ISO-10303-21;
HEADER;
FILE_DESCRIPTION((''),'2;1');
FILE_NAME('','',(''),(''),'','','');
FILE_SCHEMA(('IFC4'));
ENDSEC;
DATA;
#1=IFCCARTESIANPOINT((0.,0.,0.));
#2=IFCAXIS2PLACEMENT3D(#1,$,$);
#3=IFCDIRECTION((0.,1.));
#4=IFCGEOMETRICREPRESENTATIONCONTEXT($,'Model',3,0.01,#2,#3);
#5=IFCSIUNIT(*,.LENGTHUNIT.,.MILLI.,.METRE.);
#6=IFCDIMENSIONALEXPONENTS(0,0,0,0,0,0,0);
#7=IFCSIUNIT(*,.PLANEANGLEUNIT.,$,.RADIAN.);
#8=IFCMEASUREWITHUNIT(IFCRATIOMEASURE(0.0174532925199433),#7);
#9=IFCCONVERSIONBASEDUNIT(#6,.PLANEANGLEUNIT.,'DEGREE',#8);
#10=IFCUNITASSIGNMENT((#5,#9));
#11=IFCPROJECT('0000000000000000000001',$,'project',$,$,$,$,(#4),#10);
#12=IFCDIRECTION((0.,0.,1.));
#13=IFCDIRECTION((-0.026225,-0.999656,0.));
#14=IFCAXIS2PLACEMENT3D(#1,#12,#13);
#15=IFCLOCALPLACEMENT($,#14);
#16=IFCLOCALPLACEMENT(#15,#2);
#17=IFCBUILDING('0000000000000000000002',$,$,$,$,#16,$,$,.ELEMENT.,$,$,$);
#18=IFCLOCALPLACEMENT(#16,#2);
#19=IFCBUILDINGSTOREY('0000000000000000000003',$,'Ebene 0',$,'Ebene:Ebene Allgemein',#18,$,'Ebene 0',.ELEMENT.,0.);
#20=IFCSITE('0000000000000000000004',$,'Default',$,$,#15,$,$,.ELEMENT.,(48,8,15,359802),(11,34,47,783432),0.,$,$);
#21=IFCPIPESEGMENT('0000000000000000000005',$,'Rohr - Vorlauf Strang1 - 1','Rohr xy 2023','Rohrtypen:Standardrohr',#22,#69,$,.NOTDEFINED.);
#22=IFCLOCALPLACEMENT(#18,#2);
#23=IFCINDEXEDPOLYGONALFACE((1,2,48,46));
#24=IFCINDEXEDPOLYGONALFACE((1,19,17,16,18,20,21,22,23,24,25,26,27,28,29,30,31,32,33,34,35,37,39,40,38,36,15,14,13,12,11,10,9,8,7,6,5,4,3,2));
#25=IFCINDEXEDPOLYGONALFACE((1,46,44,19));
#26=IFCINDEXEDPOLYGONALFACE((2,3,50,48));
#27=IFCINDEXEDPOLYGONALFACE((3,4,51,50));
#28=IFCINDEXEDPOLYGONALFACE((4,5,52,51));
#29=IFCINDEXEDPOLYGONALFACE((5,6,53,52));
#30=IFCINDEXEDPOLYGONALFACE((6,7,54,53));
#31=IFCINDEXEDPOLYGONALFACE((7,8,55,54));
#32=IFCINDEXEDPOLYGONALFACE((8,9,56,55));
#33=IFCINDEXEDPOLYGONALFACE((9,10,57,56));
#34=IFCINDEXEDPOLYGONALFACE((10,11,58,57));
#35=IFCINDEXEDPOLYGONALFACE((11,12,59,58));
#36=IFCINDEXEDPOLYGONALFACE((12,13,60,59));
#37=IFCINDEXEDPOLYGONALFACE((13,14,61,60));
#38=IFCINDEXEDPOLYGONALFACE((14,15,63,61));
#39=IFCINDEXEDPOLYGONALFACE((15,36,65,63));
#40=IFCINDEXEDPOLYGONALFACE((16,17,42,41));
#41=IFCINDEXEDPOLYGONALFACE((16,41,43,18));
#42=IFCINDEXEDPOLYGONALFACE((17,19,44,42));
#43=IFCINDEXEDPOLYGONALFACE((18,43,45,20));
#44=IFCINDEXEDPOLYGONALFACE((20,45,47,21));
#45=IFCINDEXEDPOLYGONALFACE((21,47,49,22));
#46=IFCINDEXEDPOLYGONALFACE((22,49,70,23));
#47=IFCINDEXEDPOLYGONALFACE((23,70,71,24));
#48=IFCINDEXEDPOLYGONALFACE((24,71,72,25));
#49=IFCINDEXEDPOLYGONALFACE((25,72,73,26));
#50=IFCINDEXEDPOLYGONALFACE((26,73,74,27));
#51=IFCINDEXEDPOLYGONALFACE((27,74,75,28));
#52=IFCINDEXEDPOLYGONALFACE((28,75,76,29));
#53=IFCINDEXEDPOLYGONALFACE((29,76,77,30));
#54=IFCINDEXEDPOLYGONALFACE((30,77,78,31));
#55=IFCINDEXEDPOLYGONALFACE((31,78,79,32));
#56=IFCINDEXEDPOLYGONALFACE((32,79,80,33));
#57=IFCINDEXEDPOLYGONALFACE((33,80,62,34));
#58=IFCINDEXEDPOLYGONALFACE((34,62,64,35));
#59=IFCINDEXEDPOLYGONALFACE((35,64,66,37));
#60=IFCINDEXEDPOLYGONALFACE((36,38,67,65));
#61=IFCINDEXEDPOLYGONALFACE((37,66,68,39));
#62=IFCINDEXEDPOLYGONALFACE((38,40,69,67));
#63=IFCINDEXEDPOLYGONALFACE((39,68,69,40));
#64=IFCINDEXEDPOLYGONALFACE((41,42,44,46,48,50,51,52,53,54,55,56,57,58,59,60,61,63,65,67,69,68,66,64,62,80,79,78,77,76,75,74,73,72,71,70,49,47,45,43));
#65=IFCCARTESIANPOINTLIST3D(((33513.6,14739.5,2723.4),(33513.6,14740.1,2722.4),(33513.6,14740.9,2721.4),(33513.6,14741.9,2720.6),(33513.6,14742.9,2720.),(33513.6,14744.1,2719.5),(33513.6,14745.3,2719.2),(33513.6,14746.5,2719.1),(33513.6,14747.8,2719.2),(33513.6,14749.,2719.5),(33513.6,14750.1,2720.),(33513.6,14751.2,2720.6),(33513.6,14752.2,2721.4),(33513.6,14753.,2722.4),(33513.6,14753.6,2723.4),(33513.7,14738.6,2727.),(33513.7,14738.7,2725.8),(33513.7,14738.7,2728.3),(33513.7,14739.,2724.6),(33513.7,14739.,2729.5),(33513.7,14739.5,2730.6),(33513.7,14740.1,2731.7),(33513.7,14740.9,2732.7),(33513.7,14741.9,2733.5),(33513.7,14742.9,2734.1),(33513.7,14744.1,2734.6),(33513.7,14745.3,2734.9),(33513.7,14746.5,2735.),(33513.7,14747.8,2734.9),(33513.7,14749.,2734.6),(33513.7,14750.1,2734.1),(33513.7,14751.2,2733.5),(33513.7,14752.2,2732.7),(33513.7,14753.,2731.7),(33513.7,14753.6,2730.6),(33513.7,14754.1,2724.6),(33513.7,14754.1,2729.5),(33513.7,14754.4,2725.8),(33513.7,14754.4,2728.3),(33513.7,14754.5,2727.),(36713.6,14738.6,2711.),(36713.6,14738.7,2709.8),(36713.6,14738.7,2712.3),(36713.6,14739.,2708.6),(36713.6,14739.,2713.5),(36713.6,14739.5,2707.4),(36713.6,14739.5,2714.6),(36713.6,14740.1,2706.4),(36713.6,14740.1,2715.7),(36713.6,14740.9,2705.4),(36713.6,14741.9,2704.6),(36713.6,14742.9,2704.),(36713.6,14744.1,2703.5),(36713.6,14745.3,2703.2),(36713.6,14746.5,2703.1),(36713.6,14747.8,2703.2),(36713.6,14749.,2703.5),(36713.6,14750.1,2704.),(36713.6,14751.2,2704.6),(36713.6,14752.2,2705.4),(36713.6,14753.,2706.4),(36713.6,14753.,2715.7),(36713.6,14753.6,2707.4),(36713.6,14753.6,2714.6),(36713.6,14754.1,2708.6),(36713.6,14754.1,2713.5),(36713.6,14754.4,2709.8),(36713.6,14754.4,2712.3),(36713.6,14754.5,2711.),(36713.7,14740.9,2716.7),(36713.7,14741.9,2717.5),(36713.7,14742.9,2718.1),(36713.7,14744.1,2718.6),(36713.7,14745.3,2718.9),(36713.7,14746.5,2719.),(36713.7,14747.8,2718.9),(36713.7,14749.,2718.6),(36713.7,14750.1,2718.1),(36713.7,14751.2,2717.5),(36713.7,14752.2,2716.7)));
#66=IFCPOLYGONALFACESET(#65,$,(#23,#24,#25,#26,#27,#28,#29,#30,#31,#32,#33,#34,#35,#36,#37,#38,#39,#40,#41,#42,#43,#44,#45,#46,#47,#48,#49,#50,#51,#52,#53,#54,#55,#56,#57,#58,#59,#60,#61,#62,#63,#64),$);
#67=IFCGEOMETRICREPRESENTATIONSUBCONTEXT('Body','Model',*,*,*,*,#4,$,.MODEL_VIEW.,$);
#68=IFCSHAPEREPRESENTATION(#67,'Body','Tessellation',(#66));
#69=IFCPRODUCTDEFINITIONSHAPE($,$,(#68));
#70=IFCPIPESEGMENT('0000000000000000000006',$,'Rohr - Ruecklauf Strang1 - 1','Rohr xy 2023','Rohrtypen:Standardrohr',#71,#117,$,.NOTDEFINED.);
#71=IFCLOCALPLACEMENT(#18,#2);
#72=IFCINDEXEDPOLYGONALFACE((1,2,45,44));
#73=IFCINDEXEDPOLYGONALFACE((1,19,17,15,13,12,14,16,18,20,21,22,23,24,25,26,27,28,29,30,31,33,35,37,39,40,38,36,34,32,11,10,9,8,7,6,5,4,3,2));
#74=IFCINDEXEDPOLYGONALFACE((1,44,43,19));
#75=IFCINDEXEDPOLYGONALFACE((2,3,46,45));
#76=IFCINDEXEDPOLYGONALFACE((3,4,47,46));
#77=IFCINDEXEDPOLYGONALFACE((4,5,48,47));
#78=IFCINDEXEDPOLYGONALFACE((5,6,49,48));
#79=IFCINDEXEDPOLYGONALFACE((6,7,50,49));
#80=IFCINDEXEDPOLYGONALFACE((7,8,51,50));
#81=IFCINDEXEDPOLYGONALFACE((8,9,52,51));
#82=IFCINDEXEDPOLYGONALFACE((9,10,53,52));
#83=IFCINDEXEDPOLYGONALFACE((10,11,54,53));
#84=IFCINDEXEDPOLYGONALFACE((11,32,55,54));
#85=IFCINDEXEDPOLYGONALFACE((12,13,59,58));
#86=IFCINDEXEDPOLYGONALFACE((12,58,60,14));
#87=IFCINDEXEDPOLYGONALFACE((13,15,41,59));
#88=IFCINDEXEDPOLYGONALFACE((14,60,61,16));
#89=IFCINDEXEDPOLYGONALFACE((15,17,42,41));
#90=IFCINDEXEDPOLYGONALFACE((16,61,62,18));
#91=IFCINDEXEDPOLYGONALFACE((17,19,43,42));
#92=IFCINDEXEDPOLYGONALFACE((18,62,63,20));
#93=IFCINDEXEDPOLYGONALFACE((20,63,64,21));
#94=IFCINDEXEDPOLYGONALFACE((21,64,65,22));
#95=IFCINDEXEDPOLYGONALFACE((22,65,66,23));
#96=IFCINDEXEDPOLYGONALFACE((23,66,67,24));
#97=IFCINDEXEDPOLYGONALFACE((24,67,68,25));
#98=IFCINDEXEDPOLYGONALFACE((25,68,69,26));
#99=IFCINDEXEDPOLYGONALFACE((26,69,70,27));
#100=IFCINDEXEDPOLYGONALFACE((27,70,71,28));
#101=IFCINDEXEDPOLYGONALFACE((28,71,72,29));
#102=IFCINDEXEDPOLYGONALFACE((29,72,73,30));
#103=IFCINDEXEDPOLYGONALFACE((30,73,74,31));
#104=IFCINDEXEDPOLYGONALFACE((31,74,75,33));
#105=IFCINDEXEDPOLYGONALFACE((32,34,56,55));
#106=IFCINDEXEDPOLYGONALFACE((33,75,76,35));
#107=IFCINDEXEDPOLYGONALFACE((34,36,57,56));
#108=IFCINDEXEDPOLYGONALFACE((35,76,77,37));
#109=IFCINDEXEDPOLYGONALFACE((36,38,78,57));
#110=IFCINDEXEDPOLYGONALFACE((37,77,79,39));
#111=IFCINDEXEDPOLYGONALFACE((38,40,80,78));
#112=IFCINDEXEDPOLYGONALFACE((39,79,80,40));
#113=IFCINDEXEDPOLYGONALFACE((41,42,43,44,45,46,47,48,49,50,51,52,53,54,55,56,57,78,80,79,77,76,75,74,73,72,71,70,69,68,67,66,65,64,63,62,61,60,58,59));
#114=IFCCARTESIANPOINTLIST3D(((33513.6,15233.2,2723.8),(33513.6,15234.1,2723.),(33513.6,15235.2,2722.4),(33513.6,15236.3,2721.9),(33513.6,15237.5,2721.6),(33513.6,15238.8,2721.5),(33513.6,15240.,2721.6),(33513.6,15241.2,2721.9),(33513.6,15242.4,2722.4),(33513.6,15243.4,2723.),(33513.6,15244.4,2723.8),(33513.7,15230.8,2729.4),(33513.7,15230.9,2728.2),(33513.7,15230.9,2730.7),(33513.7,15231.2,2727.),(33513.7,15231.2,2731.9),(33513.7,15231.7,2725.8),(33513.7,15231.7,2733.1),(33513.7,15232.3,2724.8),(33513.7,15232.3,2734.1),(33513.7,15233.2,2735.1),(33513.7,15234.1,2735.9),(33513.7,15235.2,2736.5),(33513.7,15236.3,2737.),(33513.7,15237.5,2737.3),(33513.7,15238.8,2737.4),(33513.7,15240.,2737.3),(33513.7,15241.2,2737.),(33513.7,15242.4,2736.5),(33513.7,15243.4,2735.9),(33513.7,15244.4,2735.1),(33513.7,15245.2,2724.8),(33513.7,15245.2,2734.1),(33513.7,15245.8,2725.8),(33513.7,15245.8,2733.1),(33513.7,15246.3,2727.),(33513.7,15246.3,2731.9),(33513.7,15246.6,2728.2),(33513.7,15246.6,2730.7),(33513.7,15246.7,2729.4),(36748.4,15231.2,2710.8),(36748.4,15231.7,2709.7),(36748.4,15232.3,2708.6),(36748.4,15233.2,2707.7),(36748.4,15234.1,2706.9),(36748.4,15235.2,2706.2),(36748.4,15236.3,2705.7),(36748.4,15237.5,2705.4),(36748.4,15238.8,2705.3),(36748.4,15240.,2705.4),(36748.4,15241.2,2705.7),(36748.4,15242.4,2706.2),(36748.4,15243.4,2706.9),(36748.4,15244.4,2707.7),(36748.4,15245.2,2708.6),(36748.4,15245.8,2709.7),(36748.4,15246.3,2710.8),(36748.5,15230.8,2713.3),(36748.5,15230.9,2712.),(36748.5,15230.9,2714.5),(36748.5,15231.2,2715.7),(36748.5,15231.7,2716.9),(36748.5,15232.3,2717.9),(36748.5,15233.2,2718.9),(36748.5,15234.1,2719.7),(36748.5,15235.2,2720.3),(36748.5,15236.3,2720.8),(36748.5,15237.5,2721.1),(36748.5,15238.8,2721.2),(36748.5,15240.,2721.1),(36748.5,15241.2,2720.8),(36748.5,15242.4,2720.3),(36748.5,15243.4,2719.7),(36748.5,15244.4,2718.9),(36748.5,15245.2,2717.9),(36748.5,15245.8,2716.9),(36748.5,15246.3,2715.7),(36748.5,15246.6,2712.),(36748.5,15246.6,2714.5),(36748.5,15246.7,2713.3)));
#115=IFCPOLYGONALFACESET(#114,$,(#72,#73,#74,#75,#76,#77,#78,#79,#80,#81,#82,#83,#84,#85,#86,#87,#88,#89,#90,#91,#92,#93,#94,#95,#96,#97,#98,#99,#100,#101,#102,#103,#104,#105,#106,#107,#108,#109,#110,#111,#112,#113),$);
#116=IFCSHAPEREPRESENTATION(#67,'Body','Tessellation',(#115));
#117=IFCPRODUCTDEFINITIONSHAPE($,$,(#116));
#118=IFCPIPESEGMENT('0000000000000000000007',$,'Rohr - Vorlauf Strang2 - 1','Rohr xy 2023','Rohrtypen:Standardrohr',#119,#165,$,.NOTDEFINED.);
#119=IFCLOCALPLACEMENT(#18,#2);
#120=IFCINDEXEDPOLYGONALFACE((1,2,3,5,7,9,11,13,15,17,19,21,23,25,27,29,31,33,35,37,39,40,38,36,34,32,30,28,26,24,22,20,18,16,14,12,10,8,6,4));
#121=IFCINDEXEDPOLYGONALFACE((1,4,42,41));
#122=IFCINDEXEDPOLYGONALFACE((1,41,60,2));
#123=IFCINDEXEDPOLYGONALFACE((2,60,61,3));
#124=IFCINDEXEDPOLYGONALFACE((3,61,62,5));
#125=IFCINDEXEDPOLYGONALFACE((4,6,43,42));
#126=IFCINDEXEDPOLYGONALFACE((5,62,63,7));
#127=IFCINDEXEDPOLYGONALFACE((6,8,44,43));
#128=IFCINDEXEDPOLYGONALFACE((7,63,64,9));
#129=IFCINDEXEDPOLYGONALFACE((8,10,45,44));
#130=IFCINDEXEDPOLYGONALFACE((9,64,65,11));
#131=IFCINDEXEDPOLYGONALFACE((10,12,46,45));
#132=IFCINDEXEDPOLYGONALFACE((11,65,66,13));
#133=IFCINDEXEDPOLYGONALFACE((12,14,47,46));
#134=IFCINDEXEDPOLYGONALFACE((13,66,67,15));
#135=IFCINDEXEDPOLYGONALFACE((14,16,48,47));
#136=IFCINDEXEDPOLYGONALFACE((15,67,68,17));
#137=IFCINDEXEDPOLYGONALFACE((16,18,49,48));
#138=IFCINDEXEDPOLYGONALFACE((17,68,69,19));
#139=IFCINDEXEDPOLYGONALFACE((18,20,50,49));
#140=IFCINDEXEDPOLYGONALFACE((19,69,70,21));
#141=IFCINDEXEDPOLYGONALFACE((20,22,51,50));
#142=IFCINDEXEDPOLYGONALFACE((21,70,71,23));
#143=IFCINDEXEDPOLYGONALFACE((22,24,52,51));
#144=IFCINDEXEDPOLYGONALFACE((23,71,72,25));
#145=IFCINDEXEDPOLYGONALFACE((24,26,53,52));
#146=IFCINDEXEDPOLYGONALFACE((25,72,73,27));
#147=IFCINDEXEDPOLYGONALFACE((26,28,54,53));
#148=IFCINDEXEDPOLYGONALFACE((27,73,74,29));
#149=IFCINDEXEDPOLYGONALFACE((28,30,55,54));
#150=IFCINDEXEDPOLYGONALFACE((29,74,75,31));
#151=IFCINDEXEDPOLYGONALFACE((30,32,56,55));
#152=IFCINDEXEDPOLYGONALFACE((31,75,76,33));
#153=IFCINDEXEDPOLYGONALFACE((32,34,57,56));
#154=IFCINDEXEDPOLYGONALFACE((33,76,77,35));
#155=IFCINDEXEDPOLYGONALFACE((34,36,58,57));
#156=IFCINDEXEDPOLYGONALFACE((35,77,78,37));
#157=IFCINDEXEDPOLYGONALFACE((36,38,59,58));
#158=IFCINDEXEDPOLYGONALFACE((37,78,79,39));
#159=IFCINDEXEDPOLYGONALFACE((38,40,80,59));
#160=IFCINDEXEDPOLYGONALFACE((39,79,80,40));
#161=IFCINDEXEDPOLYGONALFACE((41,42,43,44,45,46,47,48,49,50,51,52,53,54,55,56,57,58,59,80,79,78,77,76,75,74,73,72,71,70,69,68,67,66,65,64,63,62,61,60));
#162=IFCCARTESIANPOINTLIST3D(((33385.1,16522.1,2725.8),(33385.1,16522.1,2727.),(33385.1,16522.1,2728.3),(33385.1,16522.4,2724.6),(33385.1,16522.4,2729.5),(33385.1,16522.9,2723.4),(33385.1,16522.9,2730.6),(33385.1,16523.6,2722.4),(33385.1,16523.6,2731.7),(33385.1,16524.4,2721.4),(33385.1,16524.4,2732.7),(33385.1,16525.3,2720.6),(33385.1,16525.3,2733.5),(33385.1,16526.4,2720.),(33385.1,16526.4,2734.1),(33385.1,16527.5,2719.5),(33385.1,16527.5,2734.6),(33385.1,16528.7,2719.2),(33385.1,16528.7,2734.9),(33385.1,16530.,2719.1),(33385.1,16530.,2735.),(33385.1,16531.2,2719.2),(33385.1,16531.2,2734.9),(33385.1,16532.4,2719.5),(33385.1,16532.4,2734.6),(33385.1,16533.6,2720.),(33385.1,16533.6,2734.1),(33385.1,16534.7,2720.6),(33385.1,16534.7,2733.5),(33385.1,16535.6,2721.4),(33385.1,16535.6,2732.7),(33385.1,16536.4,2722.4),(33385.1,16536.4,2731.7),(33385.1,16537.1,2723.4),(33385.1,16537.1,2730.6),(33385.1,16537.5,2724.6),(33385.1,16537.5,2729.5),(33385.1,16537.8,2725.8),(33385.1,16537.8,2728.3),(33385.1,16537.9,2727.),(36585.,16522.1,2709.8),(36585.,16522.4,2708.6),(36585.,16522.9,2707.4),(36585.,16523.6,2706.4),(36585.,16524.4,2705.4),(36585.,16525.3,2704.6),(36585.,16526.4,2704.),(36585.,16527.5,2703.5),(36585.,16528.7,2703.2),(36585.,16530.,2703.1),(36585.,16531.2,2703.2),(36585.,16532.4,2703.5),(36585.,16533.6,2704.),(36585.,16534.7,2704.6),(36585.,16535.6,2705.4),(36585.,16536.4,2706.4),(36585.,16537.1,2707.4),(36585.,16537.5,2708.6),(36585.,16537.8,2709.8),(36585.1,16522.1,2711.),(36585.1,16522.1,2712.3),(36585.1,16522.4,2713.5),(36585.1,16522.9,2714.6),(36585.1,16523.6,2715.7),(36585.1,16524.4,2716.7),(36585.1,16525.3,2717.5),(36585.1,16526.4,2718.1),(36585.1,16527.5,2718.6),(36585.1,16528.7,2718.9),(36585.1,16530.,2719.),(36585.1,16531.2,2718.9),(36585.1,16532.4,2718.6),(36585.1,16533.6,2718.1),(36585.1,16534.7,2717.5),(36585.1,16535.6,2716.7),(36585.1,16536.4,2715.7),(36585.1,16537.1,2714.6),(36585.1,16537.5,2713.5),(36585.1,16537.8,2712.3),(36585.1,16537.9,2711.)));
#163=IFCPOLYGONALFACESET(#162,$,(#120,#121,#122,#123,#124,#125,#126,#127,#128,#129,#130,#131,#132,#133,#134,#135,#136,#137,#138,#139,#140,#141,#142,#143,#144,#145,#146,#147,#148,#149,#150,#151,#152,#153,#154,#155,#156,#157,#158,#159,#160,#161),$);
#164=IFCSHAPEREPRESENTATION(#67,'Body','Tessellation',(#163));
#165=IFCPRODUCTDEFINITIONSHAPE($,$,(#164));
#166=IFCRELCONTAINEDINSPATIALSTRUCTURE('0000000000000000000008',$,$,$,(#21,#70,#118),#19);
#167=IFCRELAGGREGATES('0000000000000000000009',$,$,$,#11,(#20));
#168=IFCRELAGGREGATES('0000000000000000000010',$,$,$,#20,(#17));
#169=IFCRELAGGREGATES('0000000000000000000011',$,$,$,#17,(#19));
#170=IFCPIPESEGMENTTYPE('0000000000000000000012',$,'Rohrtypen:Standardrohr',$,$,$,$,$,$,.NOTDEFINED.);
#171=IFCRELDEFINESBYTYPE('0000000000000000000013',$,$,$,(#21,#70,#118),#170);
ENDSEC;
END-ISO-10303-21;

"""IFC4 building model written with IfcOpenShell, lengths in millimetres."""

from ifc_helpers import new_model, entity, si_unit, converted_unit, direction, frame, origin, place, context, subcontext, project, spatial, indexed_curve, outline, extrude, type_object, element, save


model = new_model("IFC4")

# Units and contexts
model_context = context("Model", 3, precision=0.01, world=origin(), true_north=direction((0.0, 1.0)))
body_context = subcontext(model_context, "Body", "Model", "MODEL_VIEW")
ifc_project = project(units=[si_unit("LENGTHUNIT", "METRE", prefix="MILLI"), converted_unit("PLANEANGLEUNIT", "DEGREE", entity("IfcRatioMeasure", 0.0174532925199433), si_unit("PLANEANGLEUNIT", "RADIAN"), dimensions=[0, 0, 0, 0, 0, 0, 0])], contexts=[model_context])

# Site, building, storey
site_placement = place(None, frame((0.0, 0.0, 0.0), z_axis=(0.0, 0.0, 1.0), x_axis=(-0.026225, -0.999656, 0.0)))
site = spatial("IfcSite", under=ifc_project, at=site_placement, Name="Default", CompositionType="ELEMENT", RefLatitude=(48, 8, 15, 359802), RefLongitude=(11, 34, 47, 783432), RefElevation=0.0)
building_placement = place(site_placement, origin())
building = spatial("IfcBuilding", under=site, at=building_placement, CompositionType="ELEMENT")
storey_placement = place(building_placement, origin())
storey = spatial("IfcBuildingStorey", under=building, at=storey_placement, Name="Ebene 0", ObjectType="Ebene:Ebene Allgemein", LongName="Ebene 0", CompositionType="ELEMENT", Elevation=0.0)

# Pipe segments
pipe_segment_type = type_object("IfcPipeSegmentType", Name="Rohrtypen:Standardrohr", PredefinedType="NOTDEFINED")
pipe_segment_1_placement = place(storey_placement, origin())
element("IfcPipeSegment", 1, at=pipe_segment_1_placement, inside=storey, type_object=pipe_segment_type, Name="Rohr - Vorlauf Strang1 - 1", Description="Rohr xy 2023", ObjectType="Rohrtypen:Standardrohr", PredefinedType="NOTDEFINED", context=body_context, shape_type="SweptSolid", body=[
    extrude(outline(indexed_curve([(7.9, 0.0), (7.8, 1.2), (7.6, 2.5), (7.1, 3.6), (6.4, 4.7), (5.6, 5.6), (4.7, 6.4), (3.6, 7.1), (2.5, 7.6), (1.2, 7.8), (0.0, 7.9), (-1.2, 7.8), (-2.5, 7.6), (-3.6, 7.1), (-4.7, 6.4), (-5.6, 5.6), (-6.4, 4.7), (-7.1, 3.6), (-7.6, 2.5), (-7.8, 1.2), (-7.9, 0.0), (-7.8, -1.2), (-7.6, -2.5), (-7.1, -3.6), (-6.4, -4.7), (-5.6, -5.6), (-4.7, -6.4), (-3.6, -7.1), (-2.5, -7.6), (-1.2, -7.8), (0.0, -7.9), (1.2, -7.8), (2.5, -7.6), (3.6, -7.1), (4.7, -6.4), (5.6, -5.6), (6.4, -4.7), (7.1, -3.6), (7.6, -2.5), (7.8, -1.2), (7.9, 0.0)], self_intersect=False)), frame((36713.6, 14746.5, 2711.0), z_axis=(-0.999988, 0.0, 0.005), x_axis=(0.0, 1.0, 0.0)), (0.0, 0.0, 1.0), 3200.0),
])
pipe_segment_2_placement = place(storey_placement, origin())
element("IfcPipeSegment", 2, at=pipe_segment_2_placement, inside=storey, type_object=pipe_segment_type, Name="Rohr - Ruecklauf Strang1 - 1", Description="Rohr xy 2023", ObjectType="Rohrtypen:Standardrohr", PredefinedType="NOTDEFINED", context=body_context, shape_type="SweptSolid", body=[
    extrude(outline(indexed_curve([(7.9, 0.0), (7.8, 1.2), (7.6, 2.5), (7.1, 3.6), (6.4, 4.7), (5.6, 5.6), (4.7, 6.4), (3.6, 7.1), (2.5, 7.6), (1.2, 7.8), (0.0, 7.9), (-1.2, 7.8), (-2.5, 7.6), (-3.6, 7.1), (-4.7, 6.4), (-5.6, 5.6), (-6.4, 4.7), (-7.1, 3.6), (-7.6, 2.5), (-7.8, 1.2), (-7.9, 0.0), (-7.8, -1.2), (-7.6, -2.5), (-7.1, -3.6), (-6.4, -4.7), (-5.6, -5.6), (-4.7, -6.4), (-3.6, -7.1), (-2.5, -7.6), (-1.2, -7.8), (0.0, -7.9), (1.2, -7.8), (2.5, -7.6), (3.6, -7.1), (4.7, -6.4), (5.6, -5.6), (6.4, -4.7), (7.1, -3.6), (7.6, -2.5), (7.8, -1.2), (7.9, 0.0)], self_intersect=False)), frame((36748.5, 15238.8, 2713.3), z_axis=(-0.999988, 0.0, 0.005), x_axis=(0.0, 1.0, 0.0)), (0.0, 0.0, 1.0), 3234.8),
])
pipe_segment_3_placement = place(storey_placement, origin())
element("IfcPipeSegment", 3, at=pipe_segment_3_placement, inside=storey, type_object=pipe_segment_type, Name="Rohr - Vorlauf Strang2 - 1", Description="Rohr xy 2023", ObjectType="Rohrtypen:Standardrohr", PredefinedType="NOTDEFINED", context=body_context, shape_type="SweptSolid", body=[
    extrude(outline(indexed_curve([(7.9, 0.0), (7.8, 1.2), (7.6, 2.5), (7.1, 3.6), (6.4, 4.7), (5.6, 5.6), (4.7, 6.4), (3.6, 7.1), (2.5, 7.6), (1.2, 7.8), (0.0, 7.9), (-1.2, 7.8), (-2.5, 7.6), (-3.6, 7.1), (-4.7, 6.4), (-5.6, 5.6), (-6.4, 4.7), (-7.1, 3.6), (-7.6, 2.5), (-7.8, 1.2), (-7.9, 0.0), (-7.8, -1.2), (-7.6, -2.5), (-7.1, -3.6), (-6.4, -4.7), (-5.6, -5.6), (-4.7, -6.4), (-3.6, -7.1), (-2.5, -7.6), (-1.2, -7.8), (0.0, -7.9), (1.2, -7.8), (2.5, -7.6), (3.6, -7.1), (4.7, -6.4), (5.6, -5.6), (6.4, -4.7), (7.1, -3.6), (7.6, -2.5), (7.8, -1.2), (7.9, 0.0)], self_intersect=False)), frame((36585.1, 16530.0, 2711.0), z_axis=(-0.999988, 0.0, 0.005), x_axis=(0.0, 1.0, 0.0)), (0.0, 0.0, 1.0), 3200.0),
])

save(model, "model.ifc")
